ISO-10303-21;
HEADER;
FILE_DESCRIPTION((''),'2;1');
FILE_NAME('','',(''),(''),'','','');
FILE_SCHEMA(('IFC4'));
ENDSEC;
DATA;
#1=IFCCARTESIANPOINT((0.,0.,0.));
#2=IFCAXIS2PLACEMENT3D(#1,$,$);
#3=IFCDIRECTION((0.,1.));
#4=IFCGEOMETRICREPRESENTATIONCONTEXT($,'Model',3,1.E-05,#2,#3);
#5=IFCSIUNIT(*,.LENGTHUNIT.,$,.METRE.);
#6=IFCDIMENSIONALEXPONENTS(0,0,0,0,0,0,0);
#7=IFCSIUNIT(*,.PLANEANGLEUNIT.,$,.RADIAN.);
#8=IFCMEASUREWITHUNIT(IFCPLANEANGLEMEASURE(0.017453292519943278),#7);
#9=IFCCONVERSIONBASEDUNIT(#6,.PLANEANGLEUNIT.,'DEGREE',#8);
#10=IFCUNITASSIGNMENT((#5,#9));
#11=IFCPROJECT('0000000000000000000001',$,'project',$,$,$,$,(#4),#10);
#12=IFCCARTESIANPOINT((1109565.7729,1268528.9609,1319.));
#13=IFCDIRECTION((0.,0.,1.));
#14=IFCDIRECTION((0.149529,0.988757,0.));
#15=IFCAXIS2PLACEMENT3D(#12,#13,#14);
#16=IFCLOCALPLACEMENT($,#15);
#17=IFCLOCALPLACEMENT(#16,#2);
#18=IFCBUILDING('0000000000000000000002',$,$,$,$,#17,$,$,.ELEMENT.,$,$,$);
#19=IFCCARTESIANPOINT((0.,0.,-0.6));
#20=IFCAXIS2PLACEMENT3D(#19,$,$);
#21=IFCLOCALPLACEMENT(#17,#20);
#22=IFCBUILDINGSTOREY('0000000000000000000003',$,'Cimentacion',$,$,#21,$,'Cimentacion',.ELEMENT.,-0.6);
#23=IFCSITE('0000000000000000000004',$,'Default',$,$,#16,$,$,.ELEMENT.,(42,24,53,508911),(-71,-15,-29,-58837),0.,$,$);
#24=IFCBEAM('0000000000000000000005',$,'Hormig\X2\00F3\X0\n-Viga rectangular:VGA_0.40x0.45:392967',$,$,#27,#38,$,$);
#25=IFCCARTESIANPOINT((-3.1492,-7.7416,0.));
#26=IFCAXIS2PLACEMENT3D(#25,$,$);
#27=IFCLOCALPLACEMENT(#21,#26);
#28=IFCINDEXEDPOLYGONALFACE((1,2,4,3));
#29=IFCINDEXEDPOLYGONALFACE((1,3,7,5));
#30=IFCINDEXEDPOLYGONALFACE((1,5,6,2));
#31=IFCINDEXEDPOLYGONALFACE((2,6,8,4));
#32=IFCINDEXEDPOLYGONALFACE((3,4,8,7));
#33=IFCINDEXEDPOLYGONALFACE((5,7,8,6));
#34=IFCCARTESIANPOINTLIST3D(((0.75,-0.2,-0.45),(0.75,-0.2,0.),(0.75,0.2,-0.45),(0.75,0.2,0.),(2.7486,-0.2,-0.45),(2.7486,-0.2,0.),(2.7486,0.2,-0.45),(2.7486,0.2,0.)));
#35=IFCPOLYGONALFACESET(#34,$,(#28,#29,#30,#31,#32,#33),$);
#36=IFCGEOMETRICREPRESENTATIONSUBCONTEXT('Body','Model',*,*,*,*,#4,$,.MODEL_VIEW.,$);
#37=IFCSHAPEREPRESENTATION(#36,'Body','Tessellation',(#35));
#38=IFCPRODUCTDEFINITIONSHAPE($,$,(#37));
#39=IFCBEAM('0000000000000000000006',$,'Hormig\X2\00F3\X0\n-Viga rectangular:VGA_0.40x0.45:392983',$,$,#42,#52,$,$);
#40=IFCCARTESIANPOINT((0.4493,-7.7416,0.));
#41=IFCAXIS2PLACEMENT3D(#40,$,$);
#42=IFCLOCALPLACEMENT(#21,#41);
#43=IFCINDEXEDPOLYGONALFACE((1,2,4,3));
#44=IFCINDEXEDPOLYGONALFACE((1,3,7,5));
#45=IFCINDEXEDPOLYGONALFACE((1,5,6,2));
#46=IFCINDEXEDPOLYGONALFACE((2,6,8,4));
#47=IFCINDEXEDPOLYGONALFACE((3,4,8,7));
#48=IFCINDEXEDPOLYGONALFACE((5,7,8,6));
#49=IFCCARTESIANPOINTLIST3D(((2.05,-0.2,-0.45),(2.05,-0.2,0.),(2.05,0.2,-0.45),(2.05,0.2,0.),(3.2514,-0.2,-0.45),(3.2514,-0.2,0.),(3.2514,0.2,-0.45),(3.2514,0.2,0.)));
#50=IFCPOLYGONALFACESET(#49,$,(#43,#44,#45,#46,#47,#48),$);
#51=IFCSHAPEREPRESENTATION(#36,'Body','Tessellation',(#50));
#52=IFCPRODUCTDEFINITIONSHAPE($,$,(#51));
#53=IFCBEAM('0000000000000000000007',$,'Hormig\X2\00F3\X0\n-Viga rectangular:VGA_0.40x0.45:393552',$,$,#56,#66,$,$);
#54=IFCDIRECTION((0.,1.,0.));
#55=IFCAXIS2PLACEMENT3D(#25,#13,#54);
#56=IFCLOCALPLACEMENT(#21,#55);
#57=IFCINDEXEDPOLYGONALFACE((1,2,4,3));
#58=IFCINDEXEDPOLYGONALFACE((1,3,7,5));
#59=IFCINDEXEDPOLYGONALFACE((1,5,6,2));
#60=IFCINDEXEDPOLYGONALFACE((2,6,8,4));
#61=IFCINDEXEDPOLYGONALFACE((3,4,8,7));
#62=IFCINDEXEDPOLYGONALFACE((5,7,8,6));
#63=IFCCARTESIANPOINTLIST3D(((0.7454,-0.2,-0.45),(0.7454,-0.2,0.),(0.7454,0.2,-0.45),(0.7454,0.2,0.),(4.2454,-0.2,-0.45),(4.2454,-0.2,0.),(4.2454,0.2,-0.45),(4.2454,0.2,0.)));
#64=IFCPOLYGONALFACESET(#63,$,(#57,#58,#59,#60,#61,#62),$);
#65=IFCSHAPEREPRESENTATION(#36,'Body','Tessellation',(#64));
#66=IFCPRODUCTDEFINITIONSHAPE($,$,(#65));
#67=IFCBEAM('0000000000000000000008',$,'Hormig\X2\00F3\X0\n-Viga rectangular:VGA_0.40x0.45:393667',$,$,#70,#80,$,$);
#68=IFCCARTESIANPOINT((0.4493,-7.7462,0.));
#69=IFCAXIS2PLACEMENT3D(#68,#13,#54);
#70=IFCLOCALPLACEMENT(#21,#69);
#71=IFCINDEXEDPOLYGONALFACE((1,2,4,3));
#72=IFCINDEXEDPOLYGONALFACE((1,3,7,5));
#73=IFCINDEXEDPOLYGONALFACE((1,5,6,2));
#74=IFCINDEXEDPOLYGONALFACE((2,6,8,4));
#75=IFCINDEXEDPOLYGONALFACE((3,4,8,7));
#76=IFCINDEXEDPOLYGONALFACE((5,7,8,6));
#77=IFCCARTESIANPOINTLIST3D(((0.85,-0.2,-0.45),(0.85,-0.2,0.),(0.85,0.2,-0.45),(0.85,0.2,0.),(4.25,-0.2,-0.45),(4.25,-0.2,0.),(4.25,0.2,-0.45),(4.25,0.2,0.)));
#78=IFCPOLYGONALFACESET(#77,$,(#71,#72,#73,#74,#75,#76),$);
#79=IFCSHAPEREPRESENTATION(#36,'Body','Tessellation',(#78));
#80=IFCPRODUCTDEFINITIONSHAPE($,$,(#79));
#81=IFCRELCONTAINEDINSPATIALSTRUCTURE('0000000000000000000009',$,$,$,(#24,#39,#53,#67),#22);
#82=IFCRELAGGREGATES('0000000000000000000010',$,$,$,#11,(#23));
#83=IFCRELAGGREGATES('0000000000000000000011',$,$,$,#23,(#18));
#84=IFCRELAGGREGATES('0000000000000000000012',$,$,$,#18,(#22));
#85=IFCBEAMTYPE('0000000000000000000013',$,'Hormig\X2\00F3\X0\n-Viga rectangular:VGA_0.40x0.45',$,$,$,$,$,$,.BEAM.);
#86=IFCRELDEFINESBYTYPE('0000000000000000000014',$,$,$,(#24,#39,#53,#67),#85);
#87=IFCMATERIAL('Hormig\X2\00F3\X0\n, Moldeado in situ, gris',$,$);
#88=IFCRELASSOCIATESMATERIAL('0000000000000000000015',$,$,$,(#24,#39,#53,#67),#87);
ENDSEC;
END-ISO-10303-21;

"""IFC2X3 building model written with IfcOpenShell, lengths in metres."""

from ifc_helpers import new_model, entity, si_unit, converted_unit, direction, frame, frame_2d, origin, place, context, subcontext, project, spatial, rectangle, extrude, material, type_object, element, save


model = new_model("IFC2X3")

# Units and contexts
model_context = context("Model", 3, precision=1e-05, world=origin(), true_north=direction((0.0, 1.0)))
body_context = subcontext(model_context, "Body", "Model", "MODEL_VIEW")
ifc_project = project(units=[si_unit("LENGTHUNIT", "METRE"), converted_unit("PLANEANGLEUNIT", "DEGREE", entity("IfcPlaneAngleMeasure", 0.017453292519943278), si_unit("PLANEANGLEUNIT", "RADIAN"), dimensions=[0, 0, 0, 0, 0, 0, 0])], contexts=[model_context])

# Site, building, storey
site_placement = place(None, frame((1109565.7729, 1268528.9609, 1319.0), z_axis=(0.0, 0.0, 1.0), x_axis=(0.149529, 0.988757, 0.0)))
site = spatial("IfcSite", under=ifc_project, at=site_placement, Name="Default", CompositionType="ELEMENT", RefLatitude=(42, 24, 53, 508911), RefLongitude=(-71, -15, -29, -58837), RefElevation=0.0)
building_placement = place(site_placement, origin())
building = spatial("IfcBuilding", under=site, at=building_placement, CompositionType="ELEMENT")
storey_placement = place(building_placement, frame((0.0, 0.0, -0.6)))
storey = spatial("IfcBuildingStorey", under=building, at=storey_placement, Name="Cimentacion", LongName="Cimentacion", CompositionType="ELEMENT", Elevation=-0.6)

# Beams
ifc_material_1 = material(Name="Hormigón, Moldeado in situ, gris")
beam_type = type_object("IfcBeamType", Name="Hormigón-Viga rectangular:VGA_0.40x0.45", PredefinedType="BEAM")
beam_1_placement = place(storey_placement, frame((-3.1492, -7.7416, 0.0)))
element("IfcBeam", 1, at=beam_1_placement, inside=storey, type_object=beam_type, material=ifc_material_1, Name="Hormigón-Viga rectangular:VGA_0.40x0.45:392967", context=body_context, shape_type="SweptSolid", body=[
    extrude(rectangle(XDim=0.45, YDim=0.4, at=frame_2d((0.0, 0.0), x_axis=(1.0, 0.0))), frame((0.75, 0.0, -0.225), z_axis=(1.0, 0.0, 0.0), x_axis=(0.0, 0.0, -1.0)), (0.0, 0.0, 1.0), 1.9986),
])
beam_2_placement = place(storey_placement, frame((0.4493, -7.7416, 0.0)))
element("IfcBeam", 2, at=beam_2_placement, inside=storey, type_object=beam_type, material=ifc_material_1, Name="Hormigón-Viga rectangular:VGA_0.40x0.45:392983", context=body_context, shape_type="SweptSolid", body=[
    extrude(rectangle(XDim=0.45, YDim=0.4, at=frame_2d((0.0, 0.0), x_axis=(1.0, 0.0))), frame((2.05, 0.0, -0.225), z_axis=(1.0, 0.0, 0.0), x_axis=(0.0, 0.0, -1.0)), (0.0, 0.0, 1.0), 1.2014),
])
beam_3_placement = place(storey_placement, frame((-3.1492, -7.7416, 0.0), z_axis=(0.0, 0.0, 1.0), x_axis=(0.0, 1.0, 0.0)))
element("IfcBeam", 3, at=beam_3_placement, inside=storey, type_object=beam_type, material=ifc_material_1, Name="Hormigón-Viga rectangular:VGA_0.40x0.45:393552", context=body_context, shape_type="SweptSolid", body=[
    extrude(rectangle(XDim=0.45, YDim=0.4, at=frame_2d((0.0, 0.0), x_axis=(1.0, 0.0))), frame((0.7454, 0.0, -0.225), z_axis=(1.0, 0.0, 0.0), x_axis=(0.0, 0.0, -1.0)), (0.0, 0.0, 1.0), 3.5),
])
beam_4_placement = place(storey_placement, frame((0.4493, -7.7462, 0.0), z_axis=(0.0, 0.0, 1.0), x_axis=(0.0, 1.0, 0.0)))
element("IfcBeam", 4, at=beam_4_placement, inside=storey, type_object=beam_type, material=ifc_material_1, Name="Hormigón-Viga rectangular:VGA_0.40x0.45:393667", context=body_context, shape_type="SweptSolid", body=[
    extrude(rectangle(XDim=0.45, YDim=0.4, at=frame_2d((0.0, 0.0), x_axis=(1.0, 0.0))), frame((0.85, 0.0, -0.225), z_axis=(1.0, 0.0, 0.0), x_axis=(0.0, 0.0, -1.0)), (0.0, 0.0, 1.0), 3.4),
])

save(model, "model.ifc")
